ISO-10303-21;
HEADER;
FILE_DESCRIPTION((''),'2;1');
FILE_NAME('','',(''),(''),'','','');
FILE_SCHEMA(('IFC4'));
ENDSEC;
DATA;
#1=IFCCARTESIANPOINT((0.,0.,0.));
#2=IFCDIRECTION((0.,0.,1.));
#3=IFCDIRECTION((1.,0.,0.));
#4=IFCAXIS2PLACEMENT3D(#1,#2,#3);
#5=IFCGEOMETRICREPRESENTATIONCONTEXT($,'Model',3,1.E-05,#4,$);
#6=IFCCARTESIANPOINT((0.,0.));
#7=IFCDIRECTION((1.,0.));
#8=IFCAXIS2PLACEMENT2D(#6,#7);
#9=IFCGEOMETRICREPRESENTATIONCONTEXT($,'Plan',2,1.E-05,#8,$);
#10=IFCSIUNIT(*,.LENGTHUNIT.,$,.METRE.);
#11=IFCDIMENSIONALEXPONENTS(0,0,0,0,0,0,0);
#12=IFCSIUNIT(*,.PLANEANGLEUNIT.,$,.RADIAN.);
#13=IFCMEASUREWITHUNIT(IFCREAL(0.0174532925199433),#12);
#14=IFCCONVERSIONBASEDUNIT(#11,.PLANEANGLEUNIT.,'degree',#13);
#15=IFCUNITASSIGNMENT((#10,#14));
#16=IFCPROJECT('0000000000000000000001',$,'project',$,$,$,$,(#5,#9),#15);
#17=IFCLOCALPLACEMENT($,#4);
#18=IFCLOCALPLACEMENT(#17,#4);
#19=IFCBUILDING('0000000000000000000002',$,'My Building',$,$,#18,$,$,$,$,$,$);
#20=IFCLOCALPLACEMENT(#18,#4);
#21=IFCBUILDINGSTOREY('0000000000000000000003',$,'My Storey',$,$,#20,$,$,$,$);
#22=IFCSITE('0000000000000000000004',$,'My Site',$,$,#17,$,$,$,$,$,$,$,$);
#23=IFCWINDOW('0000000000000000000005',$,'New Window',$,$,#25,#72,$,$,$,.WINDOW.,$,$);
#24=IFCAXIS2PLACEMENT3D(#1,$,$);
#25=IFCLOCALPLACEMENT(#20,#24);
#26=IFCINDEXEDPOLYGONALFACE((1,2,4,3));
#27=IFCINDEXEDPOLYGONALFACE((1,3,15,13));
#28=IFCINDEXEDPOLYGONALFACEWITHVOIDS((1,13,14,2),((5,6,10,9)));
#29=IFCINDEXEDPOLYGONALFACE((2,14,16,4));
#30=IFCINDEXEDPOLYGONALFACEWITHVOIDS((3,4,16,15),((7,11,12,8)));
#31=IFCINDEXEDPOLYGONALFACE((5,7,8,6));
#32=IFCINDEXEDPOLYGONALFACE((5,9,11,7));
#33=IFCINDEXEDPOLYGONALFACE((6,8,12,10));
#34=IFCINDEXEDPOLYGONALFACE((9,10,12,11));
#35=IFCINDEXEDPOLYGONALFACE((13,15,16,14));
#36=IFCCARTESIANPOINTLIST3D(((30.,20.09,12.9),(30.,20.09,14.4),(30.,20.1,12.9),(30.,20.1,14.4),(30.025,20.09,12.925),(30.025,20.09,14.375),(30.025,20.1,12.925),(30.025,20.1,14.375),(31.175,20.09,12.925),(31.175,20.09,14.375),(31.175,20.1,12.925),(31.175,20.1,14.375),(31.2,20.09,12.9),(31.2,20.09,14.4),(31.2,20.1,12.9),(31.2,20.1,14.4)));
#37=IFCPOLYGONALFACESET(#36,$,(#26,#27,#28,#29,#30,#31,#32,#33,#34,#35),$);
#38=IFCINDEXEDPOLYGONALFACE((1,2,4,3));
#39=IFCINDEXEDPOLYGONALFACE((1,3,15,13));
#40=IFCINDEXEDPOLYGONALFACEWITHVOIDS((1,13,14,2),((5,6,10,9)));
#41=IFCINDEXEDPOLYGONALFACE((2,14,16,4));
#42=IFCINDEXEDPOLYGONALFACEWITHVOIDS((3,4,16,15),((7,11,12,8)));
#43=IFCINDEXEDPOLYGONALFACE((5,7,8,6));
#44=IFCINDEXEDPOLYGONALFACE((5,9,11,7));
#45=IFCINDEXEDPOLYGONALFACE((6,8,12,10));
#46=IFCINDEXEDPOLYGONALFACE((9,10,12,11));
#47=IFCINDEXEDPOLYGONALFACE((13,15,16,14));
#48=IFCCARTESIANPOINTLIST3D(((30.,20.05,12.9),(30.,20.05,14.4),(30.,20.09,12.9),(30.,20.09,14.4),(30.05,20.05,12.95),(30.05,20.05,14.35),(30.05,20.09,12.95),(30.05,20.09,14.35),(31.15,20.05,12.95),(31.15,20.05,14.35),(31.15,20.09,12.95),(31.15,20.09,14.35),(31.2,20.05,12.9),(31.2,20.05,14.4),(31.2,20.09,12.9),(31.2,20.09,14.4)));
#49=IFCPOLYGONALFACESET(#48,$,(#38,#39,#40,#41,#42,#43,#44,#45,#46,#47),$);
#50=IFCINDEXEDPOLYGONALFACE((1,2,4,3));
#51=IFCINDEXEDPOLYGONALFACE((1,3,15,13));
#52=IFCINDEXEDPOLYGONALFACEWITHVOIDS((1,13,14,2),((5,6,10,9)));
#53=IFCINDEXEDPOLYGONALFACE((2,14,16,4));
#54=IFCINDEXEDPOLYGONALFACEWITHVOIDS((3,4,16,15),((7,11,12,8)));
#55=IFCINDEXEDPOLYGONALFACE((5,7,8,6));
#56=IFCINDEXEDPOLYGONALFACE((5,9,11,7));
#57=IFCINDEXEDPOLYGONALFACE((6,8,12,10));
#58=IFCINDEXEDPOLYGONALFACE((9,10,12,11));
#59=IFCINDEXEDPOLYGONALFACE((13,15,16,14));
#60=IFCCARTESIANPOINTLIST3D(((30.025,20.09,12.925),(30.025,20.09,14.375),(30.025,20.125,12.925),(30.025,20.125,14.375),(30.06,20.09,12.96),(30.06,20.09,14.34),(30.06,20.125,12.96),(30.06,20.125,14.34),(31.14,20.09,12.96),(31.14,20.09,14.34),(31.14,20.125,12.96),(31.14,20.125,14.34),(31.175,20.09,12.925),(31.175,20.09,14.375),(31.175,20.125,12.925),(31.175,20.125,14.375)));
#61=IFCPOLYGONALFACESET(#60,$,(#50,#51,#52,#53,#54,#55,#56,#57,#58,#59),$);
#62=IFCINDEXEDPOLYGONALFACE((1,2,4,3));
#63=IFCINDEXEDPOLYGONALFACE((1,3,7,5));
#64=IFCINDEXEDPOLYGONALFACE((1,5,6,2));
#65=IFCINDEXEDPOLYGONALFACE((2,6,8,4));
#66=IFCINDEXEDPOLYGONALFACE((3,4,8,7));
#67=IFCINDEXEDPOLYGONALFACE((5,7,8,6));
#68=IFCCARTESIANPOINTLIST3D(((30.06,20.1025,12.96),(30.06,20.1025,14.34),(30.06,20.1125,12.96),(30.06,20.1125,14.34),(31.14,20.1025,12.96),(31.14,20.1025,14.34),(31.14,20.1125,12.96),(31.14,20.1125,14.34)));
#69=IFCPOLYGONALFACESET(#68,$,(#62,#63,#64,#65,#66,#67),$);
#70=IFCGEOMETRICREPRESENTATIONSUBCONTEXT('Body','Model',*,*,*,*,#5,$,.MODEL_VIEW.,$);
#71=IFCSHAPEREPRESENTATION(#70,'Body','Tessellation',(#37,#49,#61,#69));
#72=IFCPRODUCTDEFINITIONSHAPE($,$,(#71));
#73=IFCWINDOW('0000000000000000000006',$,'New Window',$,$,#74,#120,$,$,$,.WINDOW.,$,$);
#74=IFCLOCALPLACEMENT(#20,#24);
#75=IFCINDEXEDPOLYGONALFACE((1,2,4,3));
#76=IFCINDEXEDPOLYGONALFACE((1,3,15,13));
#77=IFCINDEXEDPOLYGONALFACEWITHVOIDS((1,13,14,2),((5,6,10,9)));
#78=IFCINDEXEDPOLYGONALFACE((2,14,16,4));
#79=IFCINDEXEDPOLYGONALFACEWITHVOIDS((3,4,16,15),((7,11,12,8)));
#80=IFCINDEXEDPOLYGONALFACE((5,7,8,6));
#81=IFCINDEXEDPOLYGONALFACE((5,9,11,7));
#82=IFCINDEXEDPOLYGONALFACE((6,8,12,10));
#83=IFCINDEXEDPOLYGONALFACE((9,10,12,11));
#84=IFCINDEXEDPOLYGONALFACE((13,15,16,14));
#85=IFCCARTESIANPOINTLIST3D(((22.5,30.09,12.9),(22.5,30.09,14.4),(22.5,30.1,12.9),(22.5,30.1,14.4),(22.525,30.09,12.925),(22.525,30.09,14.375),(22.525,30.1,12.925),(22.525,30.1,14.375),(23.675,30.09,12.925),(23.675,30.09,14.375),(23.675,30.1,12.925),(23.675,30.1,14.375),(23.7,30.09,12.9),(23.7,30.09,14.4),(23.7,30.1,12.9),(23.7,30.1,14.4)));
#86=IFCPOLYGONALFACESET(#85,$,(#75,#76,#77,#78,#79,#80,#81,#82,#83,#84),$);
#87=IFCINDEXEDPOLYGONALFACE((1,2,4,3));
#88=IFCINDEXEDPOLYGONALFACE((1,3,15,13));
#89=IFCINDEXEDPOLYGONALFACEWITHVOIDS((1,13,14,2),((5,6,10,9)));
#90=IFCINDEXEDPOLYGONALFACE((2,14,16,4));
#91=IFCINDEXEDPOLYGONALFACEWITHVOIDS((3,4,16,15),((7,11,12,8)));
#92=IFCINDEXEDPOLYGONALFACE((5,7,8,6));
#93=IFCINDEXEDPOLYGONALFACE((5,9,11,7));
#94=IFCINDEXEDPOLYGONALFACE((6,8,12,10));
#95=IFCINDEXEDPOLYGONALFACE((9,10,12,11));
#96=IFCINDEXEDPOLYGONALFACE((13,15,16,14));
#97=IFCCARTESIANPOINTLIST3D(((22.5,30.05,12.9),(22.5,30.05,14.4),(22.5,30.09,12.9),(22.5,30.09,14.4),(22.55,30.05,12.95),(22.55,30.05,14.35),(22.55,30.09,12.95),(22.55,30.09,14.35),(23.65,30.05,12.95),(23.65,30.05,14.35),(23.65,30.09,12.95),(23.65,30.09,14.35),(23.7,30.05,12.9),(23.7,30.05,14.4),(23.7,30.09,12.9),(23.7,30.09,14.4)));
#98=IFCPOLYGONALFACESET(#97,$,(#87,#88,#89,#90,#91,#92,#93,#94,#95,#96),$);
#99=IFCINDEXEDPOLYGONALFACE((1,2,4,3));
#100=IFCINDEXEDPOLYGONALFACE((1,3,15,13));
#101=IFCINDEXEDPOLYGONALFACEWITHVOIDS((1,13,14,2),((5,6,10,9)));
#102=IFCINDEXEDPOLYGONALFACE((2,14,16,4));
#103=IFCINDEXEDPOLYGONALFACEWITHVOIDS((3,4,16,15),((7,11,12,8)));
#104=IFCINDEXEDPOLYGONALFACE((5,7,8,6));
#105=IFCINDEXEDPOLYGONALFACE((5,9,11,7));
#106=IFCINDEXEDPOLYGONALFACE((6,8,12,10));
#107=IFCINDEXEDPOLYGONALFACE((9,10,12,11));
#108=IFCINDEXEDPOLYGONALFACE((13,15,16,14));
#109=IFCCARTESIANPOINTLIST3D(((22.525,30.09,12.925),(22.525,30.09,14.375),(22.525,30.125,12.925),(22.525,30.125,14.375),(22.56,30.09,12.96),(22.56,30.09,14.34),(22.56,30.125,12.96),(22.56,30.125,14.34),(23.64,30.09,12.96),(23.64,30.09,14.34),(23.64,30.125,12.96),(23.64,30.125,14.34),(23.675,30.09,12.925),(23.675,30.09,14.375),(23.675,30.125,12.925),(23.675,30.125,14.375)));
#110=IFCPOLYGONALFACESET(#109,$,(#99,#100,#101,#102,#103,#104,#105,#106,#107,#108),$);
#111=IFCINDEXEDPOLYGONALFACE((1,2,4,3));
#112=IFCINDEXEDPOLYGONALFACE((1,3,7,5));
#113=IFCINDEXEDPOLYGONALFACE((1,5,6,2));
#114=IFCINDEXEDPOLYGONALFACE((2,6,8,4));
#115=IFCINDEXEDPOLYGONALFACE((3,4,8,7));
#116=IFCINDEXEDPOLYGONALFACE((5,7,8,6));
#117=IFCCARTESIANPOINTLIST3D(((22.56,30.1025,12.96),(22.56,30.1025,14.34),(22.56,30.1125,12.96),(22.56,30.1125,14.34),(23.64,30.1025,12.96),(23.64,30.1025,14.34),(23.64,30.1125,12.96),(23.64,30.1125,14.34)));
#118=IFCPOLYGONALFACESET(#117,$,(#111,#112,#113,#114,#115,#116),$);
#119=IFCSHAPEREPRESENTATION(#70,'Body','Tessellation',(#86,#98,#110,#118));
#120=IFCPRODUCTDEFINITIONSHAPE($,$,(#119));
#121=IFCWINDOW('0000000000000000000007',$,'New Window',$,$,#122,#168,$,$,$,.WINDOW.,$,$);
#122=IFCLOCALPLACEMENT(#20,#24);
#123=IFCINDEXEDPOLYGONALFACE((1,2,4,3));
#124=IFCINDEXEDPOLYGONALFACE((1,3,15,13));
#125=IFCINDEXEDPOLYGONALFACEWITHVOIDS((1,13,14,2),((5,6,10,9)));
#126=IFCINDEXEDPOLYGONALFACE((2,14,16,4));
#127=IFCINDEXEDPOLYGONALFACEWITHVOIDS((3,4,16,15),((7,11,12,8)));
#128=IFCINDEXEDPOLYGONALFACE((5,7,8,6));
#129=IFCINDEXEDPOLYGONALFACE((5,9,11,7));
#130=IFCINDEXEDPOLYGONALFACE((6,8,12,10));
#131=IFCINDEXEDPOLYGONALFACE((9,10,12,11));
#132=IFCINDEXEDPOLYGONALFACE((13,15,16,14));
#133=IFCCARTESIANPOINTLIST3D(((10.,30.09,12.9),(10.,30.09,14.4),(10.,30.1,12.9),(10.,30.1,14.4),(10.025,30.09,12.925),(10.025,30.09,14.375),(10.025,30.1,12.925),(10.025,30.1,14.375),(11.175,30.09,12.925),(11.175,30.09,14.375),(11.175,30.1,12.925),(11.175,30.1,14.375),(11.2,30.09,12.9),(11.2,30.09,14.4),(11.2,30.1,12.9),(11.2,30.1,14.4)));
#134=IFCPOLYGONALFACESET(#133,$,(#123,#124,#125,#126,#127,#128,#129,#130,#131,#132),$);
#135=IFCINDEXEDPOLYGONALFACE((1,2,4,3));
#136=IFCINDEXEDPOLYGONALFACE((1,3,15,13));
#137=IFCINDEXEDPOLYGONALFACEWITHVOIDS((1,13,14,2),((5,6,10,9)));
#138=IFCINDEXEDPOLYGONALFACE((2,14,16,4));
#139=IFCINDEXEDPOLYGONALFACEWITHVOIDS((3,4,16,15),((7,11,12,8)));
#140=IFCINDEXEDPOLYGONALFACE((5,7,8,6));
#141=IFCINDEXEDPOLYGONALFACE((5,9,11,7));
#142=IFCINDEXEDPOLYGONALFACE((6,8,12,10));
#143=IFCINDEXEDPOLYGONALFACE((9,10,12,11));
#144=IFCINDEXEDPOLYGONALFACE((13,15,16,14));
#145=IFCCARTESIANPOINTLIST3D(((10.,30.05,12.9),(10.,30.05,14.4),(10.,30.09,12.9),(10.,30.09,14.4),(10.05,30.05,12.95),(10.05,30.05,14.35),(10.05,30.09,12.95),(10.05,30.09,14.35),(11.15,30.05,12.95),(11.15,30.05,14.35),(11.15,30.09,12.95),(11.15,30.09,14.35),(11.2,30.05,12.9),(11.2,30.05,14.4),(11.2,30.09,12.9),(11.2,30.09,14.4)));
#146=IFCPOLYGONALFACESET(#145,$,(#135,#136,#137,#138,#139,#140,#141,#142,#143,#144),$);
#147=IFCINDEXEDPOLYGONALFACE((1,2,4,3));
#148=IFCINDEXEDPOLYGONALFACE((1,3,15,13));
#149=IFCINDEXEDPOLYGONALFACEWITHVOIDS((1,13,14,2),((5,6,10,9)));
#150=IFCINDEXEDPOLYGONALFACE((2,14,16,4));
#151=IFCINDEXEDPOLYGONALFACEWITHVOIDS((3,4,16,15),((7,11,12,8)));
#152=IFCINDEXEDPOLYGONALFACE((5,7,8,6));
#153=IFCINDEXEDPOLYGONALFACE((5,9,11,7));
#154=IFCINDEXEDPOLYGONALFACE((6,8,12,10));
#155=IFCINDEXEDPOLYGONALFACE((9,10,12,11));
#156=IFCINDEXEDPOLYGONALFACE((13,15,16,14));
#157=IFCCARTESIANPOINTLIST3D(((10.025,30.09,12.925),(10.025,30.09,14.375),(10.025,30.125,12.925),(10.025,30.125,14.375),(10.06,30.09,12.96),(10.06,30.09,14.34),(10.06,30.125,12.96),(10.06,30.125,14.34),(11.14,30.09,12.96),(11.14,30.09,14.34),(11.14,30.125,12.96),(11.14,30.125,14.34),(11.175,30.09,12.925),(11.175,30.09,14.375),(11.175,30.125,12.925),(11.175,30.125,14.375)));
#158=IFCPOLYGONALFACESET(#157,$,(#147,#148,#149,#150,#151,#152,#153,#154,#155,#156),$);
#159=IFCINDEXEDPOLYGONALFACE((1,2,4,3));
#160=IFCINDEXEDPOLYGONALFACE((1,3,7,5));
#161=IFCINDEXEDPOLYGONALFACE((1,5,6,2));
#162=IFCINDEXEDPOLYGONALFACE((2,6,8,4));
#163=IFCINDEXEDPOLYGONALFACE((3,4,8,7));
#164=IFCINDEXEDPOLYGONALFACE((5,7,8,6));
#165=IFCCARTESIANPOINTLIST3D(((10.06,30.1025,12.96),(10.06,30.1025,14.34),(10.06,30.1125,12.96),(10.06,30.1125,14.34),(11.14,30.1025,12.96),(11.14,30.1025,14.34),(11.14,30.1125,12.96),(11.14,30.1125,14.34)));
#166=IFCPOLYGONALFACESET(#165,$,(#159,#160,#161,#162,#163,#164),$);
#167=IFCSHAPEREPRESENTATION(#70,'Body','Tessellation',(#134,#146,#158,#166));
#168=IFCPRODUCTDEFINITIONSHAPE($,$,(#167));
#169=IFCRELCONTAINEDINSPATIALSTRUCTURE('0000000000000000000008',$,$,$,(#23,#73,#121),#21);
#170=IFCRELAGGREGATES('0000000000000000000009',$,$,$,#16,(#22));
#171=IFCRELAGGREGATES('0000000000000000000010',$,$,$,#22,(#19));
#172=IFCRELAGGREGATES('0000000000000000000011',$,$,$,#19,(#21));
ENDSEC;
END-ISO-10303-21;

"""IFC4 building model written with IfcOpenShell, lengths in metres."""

from ifc_helpers import new_model, entity, si_unit, converted_unit, frame, origin_with_axes, origin_2d_with_axis, place, context, subcontext, project, spatial, line, indexed_curve, outline, extrude, element, save


model = new_model("IFC4")

# Units and contexts
model_context = context("Model", 3, precision=1e-05, world=origin_with_axes())
plan_context = context("Plan", 2, precision=1e-05, world=origin_2d_with_axis())
body_context = subcontext(model_context, "Body", "Model", "MODEL_VIEW")
ifc_project = project(units=[si_unit("LENGTHUNIT", "METRE"), converted_unit("PLANEANGLEUNIT", "degree", entity("IfcReal", 0.0174532925199433), si_unit("PLANEANGLEUNIT", "RADIAN"), dimensions=[0, 0, 0, 0, 0, 0, 0])], contexts=[model_context, plan_context])

# Site, building, storey
site_placement = place(None, origin_with_axes())
site = spatial("IfcSite", under=ifc_project, at=site_placement, Name="My Site")
building_placement = place(site_placement, origin_with_axes())
building = spatial("IfcBuilding", under=site, at=building_placement, Name="My Building")
storey_placement = place(building_placement, origin_with_axes())
storey = spatial("IfcBuildingStorey", under=building, at=storey_placement, Name="My Storey")

# Windows
for number, where, z_axis, x_axis, name in (
    (1, (30.0, 20.0, 12.9), (0.0, 0.0, 1.0), (1.0, 0.0, 0.0), "New Window"),
    (2, (22.5, 30.0, 12.9), (0.0, 0.0, 1.0), (1.0, 0.0, 0.0), "New Window"),
    (3, (10.0, 30.0, 12.9), (0.0, 0.0, 1.0), (1.0, 0.0, 0.0), "New Window"),
):
    element("IfcWindow", number, at=place(storey_placement, frame(where, z_axis=z_axis, x_axis=x_axis)), inside=storey, Name=name, PredefinedType="WINDOW", context=body_context, shape_type="SweptSolid", body=[
        extrude(outline(indexed_curve([(0.0, 0.0), (1.2, 0.0), (1.2, 1.5), (0.0, 1.5)], segments=[line(1, 2, 3, 4, 1)]), holes=[indexed_curve([(0.025, 0.025), (1.175, 0.025), (1.175, 1.475), (0.025, 1.475)], segments=[line(1, 2, 3, 4, 1)])]), frame((0.0, 0.09, 0.0), z_axis=(0.0, -1.0, 0.0), x_axis=(1.0, 0.0, 0.0)), (0.0, 0.0, -1.0), 0.01),
        extrude(outline(indexed_curve([(0.0, 0.0), (1.2, 0.0), (1.2, 1.5), (0.0, 1.5)], segments=[line(1, 2, 3, 4, 1)]), holes=[indexed_curve([(0.05, 0.05), (1.15, 0.05), (1.15, 1.45), (0.05, 1.45)], segments=[line(1, 2, 3, 4, 1)])]), frame((0.0, 0.05, 0.0), z_axis=(0.0, -1.0, 0.0), x_axis=(1.0, 0.0, 0.0)), (0.0, 0.0, -1.0), 0.04),
        extrude(outline(indexed_curve([(0.0, 0.0), (1.15, 0.0), (1.15, 1.45), (0.0, 1.45)], segments=[line(1, 2, 3, 4, 1)]), holes=[indexed_curve([(0.035, 0.035), (1.115, 0.035), (1.115, 1.415), (0.035, 1.415)], segments=[line(1, 2, 3, 4, 1)])]), frame((0.025, 0.09, 0.025), z_axis=(0.0, -1.0, 0.0), x_axis=(1.0, 0.0, 0.0)), (0.0, 0.0, -1.0), 0.035),
        extrude(outline(indexed_curve([(0.035, 0.035), (1.115, 0.035), (1.115, 1.415), (0.035, 1.415)], segments=[line(1, 2, 3, 4, 1)])), frame((0.025, 0.1025, 0.025), z_axis=(0.0, -1.0, 0.0), x_axis=(1.0, 0.0, 0.0)), (0.0, 0.0, -1.0), 0.01),
    ])

save(model, "model.ifc")
